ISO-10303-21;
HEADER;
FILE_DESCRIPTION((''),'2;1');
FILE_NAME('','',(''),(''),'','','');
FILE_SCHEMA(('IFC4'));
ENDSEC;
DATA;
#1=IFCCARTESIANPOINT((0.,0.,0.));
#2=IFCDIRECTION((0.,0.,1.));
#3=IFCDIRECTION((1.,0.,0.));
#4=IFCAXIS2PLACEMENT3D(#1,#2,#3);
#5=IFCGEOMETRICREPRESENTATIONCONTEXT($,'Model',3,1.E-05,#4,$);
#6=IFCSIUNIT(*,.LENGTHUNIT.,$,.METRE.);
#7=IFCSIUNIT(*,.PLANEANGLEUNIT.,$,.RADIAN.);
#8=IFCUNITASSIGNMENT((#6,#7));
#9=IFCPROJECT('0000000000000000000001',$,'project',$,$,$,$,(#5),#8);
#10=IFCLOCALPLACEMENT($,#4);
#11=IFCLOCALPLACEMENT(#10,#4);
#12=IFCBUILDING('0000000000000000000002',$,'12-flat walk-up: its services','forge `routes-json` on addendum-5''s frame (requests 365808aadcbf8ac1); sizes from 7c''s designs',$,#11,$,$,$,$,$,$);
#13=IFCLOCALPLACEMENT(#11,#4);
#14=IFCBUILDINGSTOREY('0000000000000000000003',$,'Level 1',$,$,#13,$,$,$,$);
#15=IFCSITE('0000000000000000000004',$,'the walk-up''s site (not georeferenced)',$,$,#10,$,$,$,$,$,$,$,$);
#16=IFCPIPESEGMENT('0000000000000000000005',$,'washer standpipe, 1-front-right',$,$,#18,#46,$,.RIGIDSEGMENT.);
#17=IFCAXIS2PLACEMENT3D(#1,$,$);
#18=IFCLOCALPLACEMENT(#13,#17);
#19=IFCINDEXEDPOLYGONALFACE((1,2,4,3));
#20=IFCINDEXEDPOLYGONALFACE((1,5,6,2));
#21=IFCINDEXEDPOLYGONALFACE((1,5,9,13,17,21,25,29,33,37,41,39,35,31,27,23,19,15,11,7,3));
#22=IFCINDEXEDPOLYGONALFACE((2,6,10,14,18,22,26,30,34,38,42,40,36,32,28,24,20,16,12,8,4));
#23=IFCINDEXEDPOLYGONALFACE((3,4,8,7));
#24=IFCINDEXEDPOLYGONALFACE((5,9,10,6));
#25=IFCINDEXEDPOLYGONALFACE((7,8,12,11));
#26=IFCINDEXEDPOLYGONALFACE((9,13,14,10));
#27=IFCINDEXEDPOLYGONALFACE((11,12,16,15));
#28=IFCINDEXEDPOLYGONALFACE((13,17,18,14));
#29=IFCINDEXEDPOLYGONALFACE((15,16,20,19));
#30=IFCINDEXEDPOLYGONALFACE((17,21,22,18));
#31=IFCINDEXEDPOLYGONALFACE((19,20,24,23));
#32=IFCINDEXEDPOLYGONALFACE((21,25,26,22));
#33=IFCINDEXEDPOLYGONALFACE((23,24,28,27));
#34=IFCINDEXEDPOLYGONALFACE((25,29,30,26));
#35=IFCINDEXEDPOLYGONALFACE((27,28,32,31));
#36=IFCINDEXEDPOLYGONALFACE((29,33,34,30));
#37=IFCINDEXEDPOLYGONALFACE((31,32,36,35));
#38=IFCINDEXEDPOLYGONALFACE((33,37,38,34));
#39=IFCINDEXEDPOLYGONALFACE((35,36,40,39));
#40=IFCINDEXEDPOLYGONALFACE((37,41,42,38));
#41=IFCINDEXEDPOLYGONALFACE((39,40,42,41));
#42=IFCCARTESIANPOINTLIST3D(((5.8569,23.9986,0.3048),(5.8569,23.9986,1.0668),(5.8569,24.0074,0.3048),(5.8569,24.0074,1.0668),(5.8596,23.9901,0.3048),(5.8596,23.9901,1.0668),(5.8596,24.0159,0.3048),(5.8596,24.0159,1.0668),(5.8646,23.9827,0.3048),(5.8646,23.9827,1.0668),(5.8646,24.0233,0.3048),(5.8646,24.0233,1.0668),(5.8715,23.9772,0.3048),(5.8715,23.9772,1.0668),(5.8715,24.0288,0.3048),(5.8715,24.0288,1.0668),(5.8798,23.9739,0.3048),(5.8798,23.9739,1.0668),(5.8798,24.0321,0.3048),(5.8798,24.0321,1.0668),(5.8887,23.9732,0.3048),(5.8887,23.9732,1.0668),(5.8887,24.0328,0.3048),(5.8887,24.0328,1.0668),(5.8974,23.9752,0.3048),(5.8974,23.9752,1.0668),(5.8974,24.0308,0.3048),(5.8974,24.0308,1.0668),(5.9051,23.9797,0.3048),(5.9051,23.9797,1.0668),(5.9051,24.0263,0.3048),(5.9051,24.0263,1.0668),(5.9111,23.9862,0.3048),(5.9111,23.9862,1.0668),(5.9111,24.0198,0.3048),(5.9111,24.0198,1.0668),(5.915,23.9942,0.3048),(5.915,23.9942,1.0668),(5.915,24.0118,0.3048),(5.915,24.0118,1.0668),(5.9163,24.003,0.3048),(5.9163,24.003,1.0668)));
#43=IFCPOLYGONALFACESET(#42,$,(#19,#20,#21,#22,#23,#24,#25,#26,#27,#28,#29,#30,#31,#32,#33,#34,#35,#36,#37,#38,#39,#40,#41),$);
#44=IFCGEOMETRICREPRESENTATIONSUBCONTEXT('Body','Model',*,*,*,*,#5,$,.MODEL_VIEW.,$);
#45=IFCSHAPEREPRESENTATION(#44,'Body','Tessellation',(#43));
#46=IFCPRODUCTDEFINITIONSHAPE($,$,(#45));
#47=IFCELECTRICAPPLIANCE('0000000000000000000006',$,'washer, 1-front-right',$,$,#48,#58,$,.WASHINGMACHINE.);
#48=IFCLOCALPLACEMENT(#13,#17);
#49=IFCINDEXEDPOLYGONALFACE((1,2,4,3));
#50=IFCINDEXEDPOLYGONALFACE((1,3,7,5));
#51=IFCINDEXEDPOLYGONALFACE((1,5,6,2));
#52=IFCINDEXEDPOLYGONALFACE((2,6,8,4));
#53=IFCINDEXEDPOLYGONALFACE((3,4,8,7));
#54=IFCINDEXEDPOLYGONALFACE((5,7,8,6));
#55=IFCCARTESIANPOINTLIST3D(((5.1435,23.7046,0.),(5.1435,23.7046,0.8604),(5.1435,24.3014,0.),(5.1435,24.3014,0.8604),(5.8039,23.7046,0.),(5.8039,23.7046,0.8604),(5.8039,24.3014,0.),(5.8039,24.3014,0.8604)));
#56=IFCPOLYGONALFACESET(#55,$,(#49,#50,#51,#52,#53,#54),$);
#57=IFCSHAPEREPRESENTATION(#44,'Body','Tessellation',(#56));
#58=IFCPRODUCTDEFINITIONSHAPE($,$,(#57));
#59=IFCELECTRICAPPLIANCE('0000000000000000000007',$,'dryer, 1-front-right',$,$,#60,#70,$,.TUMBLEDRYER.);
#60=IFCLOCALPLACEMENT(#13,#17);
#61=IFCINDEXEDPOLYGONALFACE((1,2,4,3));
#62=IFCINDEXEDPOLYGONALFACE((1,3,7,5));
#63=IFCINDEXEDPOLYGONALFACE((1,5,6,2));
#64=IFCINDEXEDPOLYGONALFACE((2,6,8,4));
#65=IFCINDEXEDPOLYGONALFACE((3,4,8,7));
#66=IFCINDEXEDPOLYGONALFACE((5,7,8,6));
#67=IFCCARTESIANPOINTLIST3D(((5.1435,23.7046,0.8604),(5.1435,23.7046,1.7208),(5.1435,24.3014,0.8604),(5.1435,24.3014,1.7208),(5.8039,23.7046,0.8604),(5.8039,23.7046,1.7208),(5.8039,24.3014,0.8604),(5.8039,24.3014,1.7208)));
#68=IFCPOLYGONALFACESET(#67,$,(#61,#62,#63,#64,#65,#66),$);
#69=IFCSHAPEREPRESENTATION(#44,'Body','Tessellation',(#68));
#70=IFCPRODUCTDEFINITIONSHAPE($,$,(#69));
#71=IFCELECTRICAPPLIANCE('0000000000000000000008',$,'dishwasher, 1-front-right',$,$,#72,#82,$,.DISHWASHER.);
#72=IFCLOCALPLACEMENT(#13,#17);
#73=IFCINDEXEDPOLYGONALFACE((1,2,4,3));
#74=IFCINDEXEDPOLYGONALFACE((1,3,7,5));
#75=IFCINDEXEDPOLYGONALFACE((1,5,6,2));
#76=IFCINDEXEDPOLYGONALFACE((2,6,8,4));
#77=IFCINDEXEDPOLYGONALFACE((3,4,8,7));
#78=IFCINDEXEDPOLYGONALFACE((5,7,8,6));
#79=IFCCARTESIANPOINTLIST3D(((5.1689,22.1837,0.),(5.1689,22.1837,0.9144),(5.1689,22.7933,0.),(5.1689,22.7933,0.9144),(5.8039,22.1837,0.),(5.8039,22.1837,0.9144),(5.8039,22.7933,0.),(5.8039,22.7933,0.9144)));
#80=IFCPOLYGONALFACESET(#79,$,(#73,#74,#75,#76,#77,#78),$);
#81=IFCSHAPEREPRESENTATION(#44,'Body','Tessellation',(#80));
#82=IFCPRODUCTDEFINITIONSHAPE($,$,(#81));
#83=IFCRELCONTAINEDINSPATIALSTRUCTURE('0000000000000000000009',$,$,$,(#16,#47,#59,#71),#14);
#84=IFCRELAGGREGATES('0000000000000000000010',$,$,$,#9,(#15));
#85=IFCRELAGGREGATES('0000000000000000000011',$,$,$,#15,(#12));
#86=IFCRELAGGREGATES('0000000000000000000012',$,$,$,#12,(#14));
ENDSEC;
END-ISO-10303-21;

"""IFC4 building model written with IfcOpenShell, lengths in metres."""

from ifc_helpers import new_model, entity, si_unit, frame, frame_2d, origin, origin_with_axes, place, context, subcontext, project, spatial, rectangle, extrude, element, save


model = new_model("IFC4")

# Units and contexts
model_context = context("Model", 3, precision=1e-05, world=origin_with_axes())
body_context = subcontext(model_context, "Body", "Model", "MODEL_VIEW")
ifc_project = project(units=[si_unit("LENGTHUNIT", "METRE"), si_unit("PLANEANGLEUNIT", "RADIAN")], contexts=[model_context])

# Site, building, storey
site_placement = place(None, origin_with_axes())
site = spatial("IfcSite", under=ifc_project, at=site_placement, Name="the walk-up's site (not georeferenced)")
building_placement = place(site_placement, origin_with_axes())
building = spatial("IfcBuilding", under=site, at=building_placement, Name="12-flat walk-up: its services", Description="forge `routes-json` on addendum-5's frame (requests 365808aadcbf8ac1); sizes from 7c's designs")
storey_placement = place(building_placement, origin_with_axes())
storey = spatial("IfcBuildingStorey", under=building, at=storey_placement, Name="Level 1")

# Pipe segment
for number, where, z_axis, x_axis, name in (
    (1, (5.8864, 24.003, 0.3048), (0.0, 0.0, 1.0), (1.0, 0.0, 0.0), "washer standpipe, 1-front-right"),
):
    element("IfcPipeSegment", number, at=place(storey_placement, frame(where, z_axis=z_axis, x_axis=x_axis)), inside=storey, Name=name, PredefinedType="RIGIDSEGMENT", context=body_context, shape_type="AdvancedSweptSolid", body=[
        entity("IfcSweptDiskSolid", entity("IfcPolyline", [entity("IfcCartesianPoint", [0.0, 0.0, 0.0]), entity("IfcCartesianPoint", [0.0, 0.0, 0.762])]), 0.0298),
    ])

# Electric appliances
electric_appliance_1_placement = place(storey_placement, frame((5.1435, 23.7046, 0.0), z_axis=(0.0, 0.0, 1.0), x_axis=(1.0, 0.0, 0.0)))
element("IfcElectricAppliance", 2, at=electric_appliance_1_placement, inside=storey, Name="washer, 1-front-right", PredefinedType="WASHINGMACHINE", context=body_context, shape_type="SweptSolid", body=[
    extrude(rectangle(XDim=0.6604, YDim=0.5969, at=frame_2d((0.3302, 0.2984))), origin(), (0.0, 0.0, 1.0), 0.8604),
])
electric_appliance_2_placement = place(storey_placement, frame((5.1435, 23.7046, 0.8604), z_axis=(0.0, 0.0, 1.0), x_axis=(1.0, 0.0, 0.0)))
element("IfcElectricAppliance", 3, at=electric_appliance_2_placement, inside=storey, Name="dryer, 1-front-right", PredefinedType="TUMBLEDRYER", context=body_context, shape_type="SweptSolid", body=[
    extrude(rectangle(XDim=0.6604, YDim=0.5969, at=frame_2d((0.3302, 0.2984))), origin(), (0.0, 0.0, 1.0), 0.8604),
])
electric_appliance_3_placement = place(storey_placement, frame((5.1689, 22.1837, 0.0), z_axis=(0.0, 0.0, 1.0), x_axis=(1.0, 0.0, 0.0)))
element("IfcElectricAppliance", 4, at=electric_appliance_3_placement, inside=storey, Name="dishwasher, 1-front-right", PredefinedType="DISHWASHER", context=body_context, shape_type="SweptSolid", body=[
    extrude(rectangle(XDim=0.635, YDim=0.6096, at=frame_2d((0.3175, 0.3048))), origin(), (0.0, 0.0, 1.0), 0.9144),
])

save(model, "model.ifc")
